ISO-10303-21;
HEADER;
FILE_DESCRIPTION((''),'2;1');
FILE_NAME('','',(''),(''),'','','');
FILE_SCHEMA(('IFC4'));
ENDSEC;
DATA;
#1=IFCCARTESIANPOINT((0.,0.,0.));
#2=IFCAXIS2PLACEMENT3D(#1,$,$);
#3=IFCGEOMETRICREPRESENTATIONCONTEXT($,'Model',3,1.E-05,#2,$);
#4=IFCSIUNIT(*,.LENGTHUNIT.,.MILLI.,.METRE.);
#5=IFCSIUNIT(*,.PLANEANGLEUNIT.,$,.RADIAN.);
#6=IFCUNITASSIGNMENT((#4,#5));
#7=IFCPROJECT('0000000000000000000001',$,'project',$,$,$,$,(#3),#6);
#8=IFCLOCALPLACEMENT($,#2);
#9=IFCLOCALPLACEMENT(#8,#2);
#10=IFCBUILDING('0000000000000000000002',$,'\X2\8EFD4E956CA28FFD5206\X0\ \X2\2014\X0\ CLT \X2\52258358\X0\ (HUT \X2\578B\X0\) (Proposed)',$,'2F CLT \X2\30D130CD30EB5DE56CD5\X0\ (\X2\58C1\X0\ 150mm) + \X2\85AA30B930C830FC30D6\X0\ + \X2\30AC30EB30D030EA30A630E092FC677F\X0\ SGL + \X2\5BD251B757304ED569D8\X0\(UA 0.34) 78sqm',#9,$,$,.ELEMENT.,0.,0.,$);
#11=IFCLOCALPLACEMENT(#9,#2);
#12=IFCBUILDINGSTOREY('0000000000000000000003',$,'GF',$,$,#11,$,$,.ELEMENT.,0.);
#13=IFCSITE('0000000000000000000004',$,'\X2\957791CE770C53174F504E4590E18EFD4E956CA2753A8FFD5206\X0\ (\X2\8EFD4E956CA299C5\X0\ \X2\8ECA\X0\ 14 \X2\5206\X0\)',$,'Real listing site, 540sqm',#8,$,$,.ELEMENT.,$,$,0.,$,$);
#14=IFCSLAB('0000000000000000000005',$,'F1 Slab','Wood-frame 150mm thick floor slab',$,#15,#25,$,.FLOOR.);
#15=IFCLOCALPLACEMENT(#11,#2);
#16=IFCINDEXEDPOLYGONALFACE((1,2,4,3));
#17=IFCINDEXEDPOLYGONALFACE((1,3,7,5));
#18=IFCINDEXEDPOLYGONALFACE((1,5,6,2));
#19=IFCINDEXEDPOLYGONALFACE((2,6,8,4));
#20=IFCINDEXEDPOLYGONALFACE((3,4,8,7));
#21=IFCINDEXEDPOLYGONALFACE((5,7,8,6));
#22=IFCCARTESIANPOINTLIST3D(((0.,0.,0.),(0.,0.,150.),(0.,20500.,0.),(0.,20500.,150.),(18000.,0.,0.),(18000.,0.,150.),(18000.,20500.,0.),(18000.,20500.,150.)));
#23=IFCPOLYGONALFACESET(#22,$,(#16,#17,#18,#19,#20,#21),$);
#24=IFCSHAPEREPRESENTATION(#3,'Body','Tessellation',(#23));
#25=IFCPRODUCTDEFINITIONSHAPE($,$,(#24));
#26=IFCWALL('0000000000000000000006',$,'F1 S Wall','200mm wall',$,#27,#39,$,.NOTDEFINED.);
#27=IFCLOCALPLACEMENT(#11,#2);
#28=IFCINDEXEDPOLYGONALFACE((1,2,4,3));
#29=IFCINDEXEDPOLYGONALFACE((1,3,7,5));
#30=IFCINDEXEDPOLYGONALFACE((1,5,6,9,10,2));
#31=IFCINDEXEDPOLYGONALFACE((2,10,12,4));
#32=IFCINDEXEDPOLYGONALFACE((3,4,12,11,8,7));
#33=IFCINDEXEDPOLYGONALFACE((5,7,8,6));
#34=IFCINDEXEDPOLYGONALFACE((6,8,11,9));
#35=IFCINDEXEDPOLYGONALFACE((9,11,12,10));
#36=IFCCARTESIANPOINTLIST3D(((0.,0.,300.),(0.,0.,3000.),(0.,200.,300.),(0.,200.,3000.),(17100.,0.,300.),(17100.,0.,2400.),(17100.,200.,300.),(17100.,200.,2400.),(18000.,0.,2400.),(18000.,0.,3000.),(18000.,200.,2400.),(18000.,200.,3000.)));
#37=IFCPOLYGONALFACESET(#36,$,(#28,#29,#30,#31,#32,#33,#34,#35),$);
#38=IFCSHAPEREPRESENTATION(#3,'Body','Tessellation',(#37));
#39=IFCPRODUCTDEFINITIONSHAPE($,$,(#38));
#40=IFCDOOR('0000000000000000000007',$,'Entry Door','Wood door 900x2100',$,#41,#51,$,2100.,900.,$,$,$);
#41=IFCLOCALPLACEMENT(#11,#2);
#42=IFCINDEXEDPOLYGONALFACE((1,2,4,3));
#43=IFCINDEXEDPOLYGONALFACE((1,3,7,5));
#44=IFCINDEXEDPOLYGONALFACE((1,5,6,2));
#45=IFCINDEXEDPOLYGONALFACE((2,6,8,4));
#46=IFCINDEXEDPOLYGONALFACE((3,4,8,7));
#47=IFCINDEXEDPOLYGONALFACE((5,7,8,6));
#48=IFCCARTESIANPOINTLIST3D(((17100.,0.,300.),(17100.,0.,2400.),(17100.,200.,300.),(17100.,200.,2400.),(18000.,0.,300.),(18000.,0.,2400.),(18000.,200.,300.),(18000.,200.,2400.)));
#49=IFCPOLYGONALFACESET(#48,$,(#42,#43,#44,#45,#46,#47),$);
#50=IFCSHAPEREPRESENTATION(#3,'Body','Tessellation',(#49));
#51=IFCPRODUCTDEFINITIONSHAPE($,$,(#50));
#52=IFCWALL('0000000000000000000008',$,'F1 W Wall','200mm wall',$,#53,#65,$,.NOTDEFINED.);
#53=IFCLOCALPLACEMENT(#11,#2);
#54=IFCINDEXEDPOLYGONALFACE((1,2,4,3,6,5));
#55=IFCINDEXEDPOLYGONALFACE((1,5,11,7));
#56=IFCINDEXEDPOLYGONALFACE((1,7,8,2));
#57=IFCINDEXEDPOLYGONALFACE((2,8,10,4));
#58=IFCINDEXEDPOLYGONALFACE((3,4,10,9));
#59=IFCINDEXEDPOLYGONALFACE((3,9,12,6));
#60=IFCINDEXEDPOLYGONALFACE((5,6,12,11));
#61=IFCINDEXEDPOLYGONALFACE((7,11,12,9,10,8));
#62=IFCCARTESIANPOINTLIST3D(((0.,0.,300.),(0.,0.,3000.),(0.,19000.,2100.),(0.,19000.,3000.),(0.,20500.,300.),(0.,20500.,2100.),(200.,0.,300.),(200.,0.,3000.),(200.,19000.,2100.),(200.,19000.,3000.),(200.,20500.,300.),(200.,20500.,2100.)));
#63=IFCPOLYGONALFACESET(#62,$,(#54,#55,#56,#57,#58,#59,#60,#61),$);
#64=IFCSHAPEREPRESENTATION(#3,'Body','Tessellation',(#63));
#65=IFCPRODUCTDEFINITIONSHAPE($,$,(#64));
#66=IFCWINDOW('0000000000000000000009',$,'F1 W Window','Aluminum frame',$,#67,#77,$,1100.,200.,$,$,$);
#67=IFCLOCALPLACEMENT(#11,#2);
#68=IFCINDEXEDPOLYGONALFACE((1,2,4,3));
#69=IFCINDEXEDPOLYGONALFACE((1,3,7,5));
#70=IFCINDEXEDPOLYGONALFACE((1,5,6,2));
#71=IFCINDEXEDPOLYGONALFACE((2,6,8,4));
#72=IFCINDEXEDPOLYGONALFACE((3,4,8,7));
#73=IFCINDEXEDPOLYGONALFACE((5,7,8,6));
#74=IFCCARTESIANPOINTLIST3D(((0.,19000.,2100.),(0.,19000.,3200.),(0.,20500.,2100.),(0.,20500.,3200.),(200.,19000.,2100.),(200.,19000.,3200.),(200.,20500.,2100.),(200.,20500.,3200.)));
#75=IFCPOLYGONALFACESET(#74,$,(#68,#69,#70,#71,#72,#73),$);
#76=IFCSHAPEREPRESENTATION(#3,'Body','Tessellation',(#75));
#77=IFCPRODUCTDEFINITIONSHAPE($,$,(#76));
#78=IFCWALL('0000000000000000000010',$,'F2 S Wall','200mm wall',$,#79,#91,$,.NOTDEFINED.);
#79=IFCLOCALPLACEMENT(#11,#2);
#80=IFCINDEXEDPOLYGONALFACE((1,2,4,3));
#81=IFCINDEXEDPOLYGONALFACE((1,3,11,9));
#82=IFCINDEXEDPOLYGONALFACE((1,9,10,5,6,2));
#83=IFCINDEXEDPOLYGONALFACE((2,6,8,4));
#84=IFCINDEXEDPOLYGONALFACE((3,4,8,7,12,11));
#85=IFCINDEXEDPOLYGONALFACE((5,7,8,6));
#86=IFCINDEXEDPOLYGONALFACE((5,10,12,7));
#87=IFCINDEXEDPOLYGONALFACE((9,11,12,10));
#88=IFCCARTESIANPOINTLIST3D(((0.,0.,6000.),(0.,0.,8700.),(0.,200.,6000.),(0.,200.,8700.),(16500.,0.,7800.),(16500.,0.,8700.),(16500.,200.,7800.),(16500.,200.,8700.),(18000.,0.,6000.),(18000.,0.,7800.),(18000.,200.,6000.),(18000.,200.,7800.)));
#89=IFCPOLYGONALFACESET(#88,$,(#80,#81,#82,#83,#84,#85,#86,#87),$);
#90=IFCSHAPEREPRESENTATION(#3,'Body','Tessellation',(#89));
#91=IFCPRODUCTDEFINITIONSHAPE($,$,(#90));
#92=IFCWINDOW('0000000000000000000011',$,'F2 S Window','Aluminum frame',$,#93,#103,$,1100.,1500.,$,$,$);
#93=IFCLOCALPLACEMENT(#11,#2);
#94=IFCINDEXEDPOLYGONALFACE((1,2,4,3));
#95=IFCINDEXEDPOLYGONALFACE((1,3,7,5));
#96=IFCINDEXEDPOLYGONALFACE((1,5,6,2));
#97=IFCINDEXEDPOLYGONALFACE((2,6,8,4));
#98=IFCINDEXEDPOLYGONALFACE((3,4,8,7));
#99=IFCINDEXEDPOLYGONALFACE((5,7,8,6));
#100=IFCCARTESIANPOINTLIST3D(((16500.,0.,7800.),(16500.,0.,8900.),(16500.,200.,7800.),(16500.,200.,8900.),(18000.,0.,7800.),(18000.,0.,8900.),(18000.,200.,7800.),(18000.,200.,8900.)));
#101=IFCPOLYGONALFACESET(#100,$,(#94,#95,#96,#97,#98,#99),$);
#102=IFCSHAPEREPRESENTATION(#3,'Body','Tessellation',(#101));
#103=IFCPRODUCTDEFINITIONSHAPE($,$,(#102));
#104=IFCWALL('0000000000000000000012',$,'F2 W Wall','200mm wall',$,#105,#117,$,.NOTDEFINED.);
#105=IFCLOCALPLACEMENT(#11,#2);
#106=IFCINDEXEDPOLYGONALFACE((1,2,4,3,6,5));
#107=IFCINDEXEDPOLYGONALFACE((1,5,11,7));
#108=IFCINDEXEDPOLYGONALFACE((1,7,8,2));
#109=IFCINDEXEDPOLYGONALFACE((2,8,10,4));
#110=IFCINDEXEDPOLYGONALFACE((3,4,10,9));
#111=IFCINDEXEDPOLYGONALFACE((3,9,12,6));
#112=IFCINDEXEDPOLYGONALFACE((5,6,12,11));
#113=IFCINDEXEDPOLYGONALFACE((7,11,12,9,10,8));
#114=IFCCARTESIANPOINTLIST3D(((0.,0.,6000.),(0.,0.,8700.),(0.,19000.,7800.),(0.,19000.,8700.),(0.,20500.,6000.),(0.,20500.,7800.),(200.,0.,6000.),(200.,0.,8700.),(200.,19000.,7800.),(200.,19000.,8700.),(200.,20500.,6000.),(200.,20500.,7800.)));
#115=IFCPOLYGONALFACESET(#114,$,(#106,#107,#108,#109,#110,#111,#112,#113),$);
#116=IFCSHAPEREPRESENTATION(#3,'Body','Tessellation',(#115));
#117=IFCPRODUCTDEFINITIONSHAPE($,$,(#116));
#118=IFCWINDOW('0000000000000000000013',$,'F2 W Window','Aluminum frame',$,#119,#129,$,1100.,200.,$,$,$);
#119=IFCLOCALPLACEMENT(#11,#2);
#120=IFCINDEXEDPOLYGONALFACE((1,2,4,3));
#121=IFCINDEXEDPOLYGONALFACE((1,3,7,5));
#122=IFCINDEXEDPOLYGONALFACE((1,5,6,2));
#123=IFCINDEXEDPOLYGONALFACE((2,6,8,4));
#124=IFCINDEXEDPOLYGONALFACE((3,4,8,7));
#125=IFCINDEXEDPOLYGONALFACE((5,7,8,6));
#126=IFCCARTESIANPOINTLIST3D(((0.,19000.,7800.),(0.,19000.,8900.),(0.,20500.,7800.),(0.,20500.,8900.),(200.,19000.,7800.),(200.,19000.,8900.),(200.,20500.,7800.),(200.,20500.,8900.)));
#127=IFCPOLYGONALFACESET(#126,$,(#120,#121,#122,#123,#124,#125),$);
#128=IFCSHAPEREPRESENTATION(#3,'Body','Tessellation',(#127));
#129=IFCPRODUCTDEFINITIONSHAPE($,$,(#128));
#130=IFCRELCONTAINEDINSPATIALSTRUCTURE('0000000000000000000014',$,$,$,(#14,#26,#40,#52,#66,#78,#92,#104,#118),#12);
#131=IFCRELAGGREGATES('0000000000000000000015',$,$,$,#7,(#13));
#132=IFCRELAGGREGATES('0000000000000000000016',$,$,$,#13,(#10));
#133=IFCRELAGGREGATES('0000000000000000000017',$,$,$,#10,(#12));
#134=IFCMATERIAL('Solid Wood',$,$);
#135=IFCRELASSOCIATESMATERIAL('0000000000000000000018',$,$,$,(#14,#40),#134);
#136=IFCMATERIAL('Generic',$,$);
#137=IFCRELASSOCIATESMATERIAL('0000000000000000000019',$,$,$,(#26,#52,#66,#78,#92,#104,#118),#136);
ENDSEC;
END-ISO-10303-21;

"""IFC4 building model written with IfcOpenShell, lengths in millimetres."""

from ifc_helpers import new_model, si_unit, frame, frame_2d, origin, place, context, project, spatial, rectangle, extrude, material, element, fill, save


model = new_model("IFC4")

# Units and contexts
model_context = context("Model", 3, precision=1e-05, world=origin())
ifc_project = project(units=[si_unit("LENGTHUNIT", "METRE", prefix="MILLI"), si_unit("PLANEANGLEUNIT", "RADIAN")], contexts=[model_context])

# Site, building, storey
site_placement = place(None, origin())
site = spatial("IfcSite", under=ifc_project, at=site_placement, Name="長野県北佐久郡軽井沢町追分 (軽井沢駅 車 14 分)", ObjectType="Real listing site, 540sqm", CompositionType="ELEMENT", RefElevation=0.0)
building_placement = place(site_placement, origin())
building = spatial("IfcBuilding", under=site, at=building_placement, Name="軽井沢追分 — CLT 別荘 (HUT 型) (Proposed)", ObjectType="2F CLT パネル工法 (壁 150mm) + 薪ストーブ + ガルバリウム鋼板 SGL + 寒冷地仕様(UA 0.34) 78sqm", CompositionType="ELEMENT", ElevationOfRefHeight=0.0, ElevationOfTerrain=0.0)
storey_placement = place(building_placement, origin())
storey = spatial("IfcBuildingStorey", under=building, at=storey_placement, Name="GF", CompositionType="ELEMENT", Elevation=0.0)

# Slab
ifc_material_1 = material(Name="Solid Wood")
slab_1_placement = place(storey_placement, origin())
element("IfcSlab", 1, at=slab_1_placement, inside=storey, material=ifc_material_1, Name="F1 Slab", Description="Wood-frame 150mm thick floor slab", PredefinedType="FLOOR", context=model_context, shape_type="SweptSolid", body=[
    extrude(rectangle(XDim=18000.0, YDim=20500.0, at=frame_2d((9000.0, 10250.0))), origin(), (0.0, 0.0, 1.0), 150.0),
])

# Shared definitions
ifc_material_2 = material(Name="Generic")

# Wall, opening, door
wall_1_placement = place(storey_placement, frame((0.0, 0.0, 150.0)))
wall_1 = element("IfcWall", 2, at=wall_1_placement, inside=storey, material=ifc_material_2, Name="F1 S Wall", Description="200mm wall", PredefinedType="NOTDEFINED", context=model_context, shape_type="SweptSolid", body=[
    extrude(rectangle(XDim=18000.0, YDim=200.0, at=frame_2d((9000.0, 100.0))), frame((0.0, 0.0, 150.0)), (0.0, 0.0, 1.0), 2700.0),
])
opening_1_placement = place(storey_placement, frame((8550.0, 0.0, 150.0)))
opening_1 = element("IfcOpeningElement", 3, at=opening_1_placement, cuts=wall_1, PredefinedType="NOTDEFINED", context=model_context, shape_type="SweptSolid", body=[
    extrude(rectangle(XDim=900.0, YDim=200.0, at=frame_2d((450.0, 100.0))), frame((8550.0, 0.0, 150.0)), (0.0, 0.0, 1.0), 2100.0),
])
door_placement = place(storey_placement, frame((8550.0, 0.0, 150.0)))
door = element("IfcDoor", 4, at=door_placement, inside=storey, material=ifc_material_1, Name="Entry Door", Description="Wood door 900x2100", OverallHeight=2100.0, OverallWidth=900.0, context=model_context, shape_type="SweptSolid", body=[
    extrude(rectangle(XDim=900.0, YDim=200.0, at=frame_2d((450.0, 100.0))), frame((8550.0, 0.0, 150.0)), (0.0, 0.0, 1.0), 2100.0),
])
fill(opening_1, door)

# Walls, openings, windows
wall_2_placement = place(storey_placement, frame((0.0, 0.0, 150.0)))
wall_2 = element("IfcWall", 5, at=wall_2_placement, inside=storey, material=ifc_material_2, Name="F1 W Wall", Description="200mm wall", PredefinedType="NOTDEFINED", context=model_context, shape_type="SweptSolid", body=[
    extrude(rectangle(XDim=200.0, YDim=20500.0, at=frame_2d((100.0, 10250.0))), frame((0.0, 0.0, 150.0)), (0.0, 0.0, 1.0), 2700.0),
])
opening_2_placement = place(storey_placement, frame((0.0, 9500.0, 1050.0)))
opening_2 = element("IfcOpeningElement", 6, at=opening_2_placement, cuts=wall_2, PredefinedType="NOTDEFINED", context=model_context, shape_type="SweptSolid", body=[
    extrude(rectangle(XDim=200.0, YDim=1500.0, at=frame_2d((100.0, 750.0))), frame((0.0, 9500.0, 1050.0)), (0.0, 0.0, 1.0), 1100.0),
])
window_1_placement = place(storey_placement, frame((0.0, 9500.0, 1050.0)))
window_1 = element("IfcWindow", 7, at=window_1_placement, inside=storey, material=ifc_material_2, Name="F1 W Window", Description="Aluminum frame", OverallHeight=1100.0, OverallWidth=200.0, context=model_context, shape_type="SweptSolid", body=[
    extrude(rectangle(XDim=200.0, YDim=1500.0, at=frame_2d((100.0, 750.0))), frame((0.0, 9500.0, 1050.0)), (0.0, 0.0, 1.0), 1100.0),
])
fill(opening_2, window_1)
wall_3_placement = place(storey_placement, frame((0.0, 0.0, 3000.0)))
wall_3 = element("IfcWall", 8, at=wall_3_placement, inside=storey, material=ifc_material_2, Name="F2 S Wall", Description="200mm wall", PredefinedType="NOTDEFINED", context=model_context, shape_type="SweptSolid", body=[
    extrude(rectangle(XDim=18000.0, YDim=200.0, at=frame_2d((9000.0, 100.0))), frame((0.0, 0.0, 3000.0)), (0.0, 0.0, 1.0), 2700.0),
])
opening_3_placement = place(storey_placement, frame((8250.0, 0.0, 3900.0)))
opening_3 = element("IfcOpeningElement", 9, at=opening_3_placement, cuts=wall_3, PredefinedType="NOTDEFINED", context=model_context, shape_type="SweptSolid", body=[
    extrude(rectangle(XDim=1500.0, YDim=200.0, at=frame_2d((750.0, 100.0))), frame((8250.0, 0.0, 3900.0)), (0.0, 0.0, 1.0), 1100.0),
])
window_2_placement = place(storey_placement, frame((8250.0, 0.0, 3900.0)))
window_2 = element("IfcWindow", 10, at=window_2_placement, inside=storey, material=ifc_material_2, Name="F2 S Window", Description="Aluminum frame", OverallHeight=1100.0, OverallWidth=1500.0, context=model_context, shape_type="SweptSolid", body=[
    extrude(rectangle(XDim=1500.0, YDim=200.0, at=frame_2d((750.0, 100.0))), frame((8250.0, 0.0, 3900.0)), (0.0, 0.0, 1.0), 1100.0),
])
fill(opening_3, window_2)
wall_4_placement = place(storey_placement, frame((0.0, 0.0, 3000.0)))
wall_4 = element("IfcWall", 11, at=wall_4_placement, inside=storey, material=ifc_material_2, Name="F2 W Wall", Description="200mm wall", PredefinedType="NOTDEFINED", context=model_context, shape_type="SweptSolid", body=[
    extrude(rectangle(XDim=200.0, YDim=20500.0, at=frame_2d((100.0, 10250.0))), frame((0.0, 0.0, 3000.0)), (0.0, 0.0, 1.0), 2700.0),
])
opening_4_placement = place(storey_placement, frame((0.0, 9500.0, 3900.0)))
opening_4 = element("IfcOpeningElement", 12, at=opening_4_placement, cuts=wall_4, PredefinedType="NOTDEFINED", context=model_context, shape_type="SweptSolid", body=[
    extrude(rectangle(XDim=200.0, YDim=1500.0, at=frame_2d((100.0, 750.0))), frame((0.0, 9500.0, 3900.0)), (0.0, 0.0, 1.0), 1100.0),
])
window_3_placement = place(storey_placement, frame((0.0, 9500.0, 3900.0)))
window_3 = element("IfcWindow", 13, at=window_3_placement, inside=storey, material=ifc_material_2, Name="F2 W Window", Description="Aluminum frame", OverallHeight=1100.0, OverallWidth=200.0, context=model_context, shape_type="SweptSolid", body=[
    extrude(rectangle(XDim=200.0, YDim=1500.0, at=frame_2d((100.0, 750.0))), frame((0.0, 9500.0, 3900.0)), (0.0, 0.0, 1.0), 1100.0),
])
fill(opening_4, window_3)

save(model, "model.ifc")
